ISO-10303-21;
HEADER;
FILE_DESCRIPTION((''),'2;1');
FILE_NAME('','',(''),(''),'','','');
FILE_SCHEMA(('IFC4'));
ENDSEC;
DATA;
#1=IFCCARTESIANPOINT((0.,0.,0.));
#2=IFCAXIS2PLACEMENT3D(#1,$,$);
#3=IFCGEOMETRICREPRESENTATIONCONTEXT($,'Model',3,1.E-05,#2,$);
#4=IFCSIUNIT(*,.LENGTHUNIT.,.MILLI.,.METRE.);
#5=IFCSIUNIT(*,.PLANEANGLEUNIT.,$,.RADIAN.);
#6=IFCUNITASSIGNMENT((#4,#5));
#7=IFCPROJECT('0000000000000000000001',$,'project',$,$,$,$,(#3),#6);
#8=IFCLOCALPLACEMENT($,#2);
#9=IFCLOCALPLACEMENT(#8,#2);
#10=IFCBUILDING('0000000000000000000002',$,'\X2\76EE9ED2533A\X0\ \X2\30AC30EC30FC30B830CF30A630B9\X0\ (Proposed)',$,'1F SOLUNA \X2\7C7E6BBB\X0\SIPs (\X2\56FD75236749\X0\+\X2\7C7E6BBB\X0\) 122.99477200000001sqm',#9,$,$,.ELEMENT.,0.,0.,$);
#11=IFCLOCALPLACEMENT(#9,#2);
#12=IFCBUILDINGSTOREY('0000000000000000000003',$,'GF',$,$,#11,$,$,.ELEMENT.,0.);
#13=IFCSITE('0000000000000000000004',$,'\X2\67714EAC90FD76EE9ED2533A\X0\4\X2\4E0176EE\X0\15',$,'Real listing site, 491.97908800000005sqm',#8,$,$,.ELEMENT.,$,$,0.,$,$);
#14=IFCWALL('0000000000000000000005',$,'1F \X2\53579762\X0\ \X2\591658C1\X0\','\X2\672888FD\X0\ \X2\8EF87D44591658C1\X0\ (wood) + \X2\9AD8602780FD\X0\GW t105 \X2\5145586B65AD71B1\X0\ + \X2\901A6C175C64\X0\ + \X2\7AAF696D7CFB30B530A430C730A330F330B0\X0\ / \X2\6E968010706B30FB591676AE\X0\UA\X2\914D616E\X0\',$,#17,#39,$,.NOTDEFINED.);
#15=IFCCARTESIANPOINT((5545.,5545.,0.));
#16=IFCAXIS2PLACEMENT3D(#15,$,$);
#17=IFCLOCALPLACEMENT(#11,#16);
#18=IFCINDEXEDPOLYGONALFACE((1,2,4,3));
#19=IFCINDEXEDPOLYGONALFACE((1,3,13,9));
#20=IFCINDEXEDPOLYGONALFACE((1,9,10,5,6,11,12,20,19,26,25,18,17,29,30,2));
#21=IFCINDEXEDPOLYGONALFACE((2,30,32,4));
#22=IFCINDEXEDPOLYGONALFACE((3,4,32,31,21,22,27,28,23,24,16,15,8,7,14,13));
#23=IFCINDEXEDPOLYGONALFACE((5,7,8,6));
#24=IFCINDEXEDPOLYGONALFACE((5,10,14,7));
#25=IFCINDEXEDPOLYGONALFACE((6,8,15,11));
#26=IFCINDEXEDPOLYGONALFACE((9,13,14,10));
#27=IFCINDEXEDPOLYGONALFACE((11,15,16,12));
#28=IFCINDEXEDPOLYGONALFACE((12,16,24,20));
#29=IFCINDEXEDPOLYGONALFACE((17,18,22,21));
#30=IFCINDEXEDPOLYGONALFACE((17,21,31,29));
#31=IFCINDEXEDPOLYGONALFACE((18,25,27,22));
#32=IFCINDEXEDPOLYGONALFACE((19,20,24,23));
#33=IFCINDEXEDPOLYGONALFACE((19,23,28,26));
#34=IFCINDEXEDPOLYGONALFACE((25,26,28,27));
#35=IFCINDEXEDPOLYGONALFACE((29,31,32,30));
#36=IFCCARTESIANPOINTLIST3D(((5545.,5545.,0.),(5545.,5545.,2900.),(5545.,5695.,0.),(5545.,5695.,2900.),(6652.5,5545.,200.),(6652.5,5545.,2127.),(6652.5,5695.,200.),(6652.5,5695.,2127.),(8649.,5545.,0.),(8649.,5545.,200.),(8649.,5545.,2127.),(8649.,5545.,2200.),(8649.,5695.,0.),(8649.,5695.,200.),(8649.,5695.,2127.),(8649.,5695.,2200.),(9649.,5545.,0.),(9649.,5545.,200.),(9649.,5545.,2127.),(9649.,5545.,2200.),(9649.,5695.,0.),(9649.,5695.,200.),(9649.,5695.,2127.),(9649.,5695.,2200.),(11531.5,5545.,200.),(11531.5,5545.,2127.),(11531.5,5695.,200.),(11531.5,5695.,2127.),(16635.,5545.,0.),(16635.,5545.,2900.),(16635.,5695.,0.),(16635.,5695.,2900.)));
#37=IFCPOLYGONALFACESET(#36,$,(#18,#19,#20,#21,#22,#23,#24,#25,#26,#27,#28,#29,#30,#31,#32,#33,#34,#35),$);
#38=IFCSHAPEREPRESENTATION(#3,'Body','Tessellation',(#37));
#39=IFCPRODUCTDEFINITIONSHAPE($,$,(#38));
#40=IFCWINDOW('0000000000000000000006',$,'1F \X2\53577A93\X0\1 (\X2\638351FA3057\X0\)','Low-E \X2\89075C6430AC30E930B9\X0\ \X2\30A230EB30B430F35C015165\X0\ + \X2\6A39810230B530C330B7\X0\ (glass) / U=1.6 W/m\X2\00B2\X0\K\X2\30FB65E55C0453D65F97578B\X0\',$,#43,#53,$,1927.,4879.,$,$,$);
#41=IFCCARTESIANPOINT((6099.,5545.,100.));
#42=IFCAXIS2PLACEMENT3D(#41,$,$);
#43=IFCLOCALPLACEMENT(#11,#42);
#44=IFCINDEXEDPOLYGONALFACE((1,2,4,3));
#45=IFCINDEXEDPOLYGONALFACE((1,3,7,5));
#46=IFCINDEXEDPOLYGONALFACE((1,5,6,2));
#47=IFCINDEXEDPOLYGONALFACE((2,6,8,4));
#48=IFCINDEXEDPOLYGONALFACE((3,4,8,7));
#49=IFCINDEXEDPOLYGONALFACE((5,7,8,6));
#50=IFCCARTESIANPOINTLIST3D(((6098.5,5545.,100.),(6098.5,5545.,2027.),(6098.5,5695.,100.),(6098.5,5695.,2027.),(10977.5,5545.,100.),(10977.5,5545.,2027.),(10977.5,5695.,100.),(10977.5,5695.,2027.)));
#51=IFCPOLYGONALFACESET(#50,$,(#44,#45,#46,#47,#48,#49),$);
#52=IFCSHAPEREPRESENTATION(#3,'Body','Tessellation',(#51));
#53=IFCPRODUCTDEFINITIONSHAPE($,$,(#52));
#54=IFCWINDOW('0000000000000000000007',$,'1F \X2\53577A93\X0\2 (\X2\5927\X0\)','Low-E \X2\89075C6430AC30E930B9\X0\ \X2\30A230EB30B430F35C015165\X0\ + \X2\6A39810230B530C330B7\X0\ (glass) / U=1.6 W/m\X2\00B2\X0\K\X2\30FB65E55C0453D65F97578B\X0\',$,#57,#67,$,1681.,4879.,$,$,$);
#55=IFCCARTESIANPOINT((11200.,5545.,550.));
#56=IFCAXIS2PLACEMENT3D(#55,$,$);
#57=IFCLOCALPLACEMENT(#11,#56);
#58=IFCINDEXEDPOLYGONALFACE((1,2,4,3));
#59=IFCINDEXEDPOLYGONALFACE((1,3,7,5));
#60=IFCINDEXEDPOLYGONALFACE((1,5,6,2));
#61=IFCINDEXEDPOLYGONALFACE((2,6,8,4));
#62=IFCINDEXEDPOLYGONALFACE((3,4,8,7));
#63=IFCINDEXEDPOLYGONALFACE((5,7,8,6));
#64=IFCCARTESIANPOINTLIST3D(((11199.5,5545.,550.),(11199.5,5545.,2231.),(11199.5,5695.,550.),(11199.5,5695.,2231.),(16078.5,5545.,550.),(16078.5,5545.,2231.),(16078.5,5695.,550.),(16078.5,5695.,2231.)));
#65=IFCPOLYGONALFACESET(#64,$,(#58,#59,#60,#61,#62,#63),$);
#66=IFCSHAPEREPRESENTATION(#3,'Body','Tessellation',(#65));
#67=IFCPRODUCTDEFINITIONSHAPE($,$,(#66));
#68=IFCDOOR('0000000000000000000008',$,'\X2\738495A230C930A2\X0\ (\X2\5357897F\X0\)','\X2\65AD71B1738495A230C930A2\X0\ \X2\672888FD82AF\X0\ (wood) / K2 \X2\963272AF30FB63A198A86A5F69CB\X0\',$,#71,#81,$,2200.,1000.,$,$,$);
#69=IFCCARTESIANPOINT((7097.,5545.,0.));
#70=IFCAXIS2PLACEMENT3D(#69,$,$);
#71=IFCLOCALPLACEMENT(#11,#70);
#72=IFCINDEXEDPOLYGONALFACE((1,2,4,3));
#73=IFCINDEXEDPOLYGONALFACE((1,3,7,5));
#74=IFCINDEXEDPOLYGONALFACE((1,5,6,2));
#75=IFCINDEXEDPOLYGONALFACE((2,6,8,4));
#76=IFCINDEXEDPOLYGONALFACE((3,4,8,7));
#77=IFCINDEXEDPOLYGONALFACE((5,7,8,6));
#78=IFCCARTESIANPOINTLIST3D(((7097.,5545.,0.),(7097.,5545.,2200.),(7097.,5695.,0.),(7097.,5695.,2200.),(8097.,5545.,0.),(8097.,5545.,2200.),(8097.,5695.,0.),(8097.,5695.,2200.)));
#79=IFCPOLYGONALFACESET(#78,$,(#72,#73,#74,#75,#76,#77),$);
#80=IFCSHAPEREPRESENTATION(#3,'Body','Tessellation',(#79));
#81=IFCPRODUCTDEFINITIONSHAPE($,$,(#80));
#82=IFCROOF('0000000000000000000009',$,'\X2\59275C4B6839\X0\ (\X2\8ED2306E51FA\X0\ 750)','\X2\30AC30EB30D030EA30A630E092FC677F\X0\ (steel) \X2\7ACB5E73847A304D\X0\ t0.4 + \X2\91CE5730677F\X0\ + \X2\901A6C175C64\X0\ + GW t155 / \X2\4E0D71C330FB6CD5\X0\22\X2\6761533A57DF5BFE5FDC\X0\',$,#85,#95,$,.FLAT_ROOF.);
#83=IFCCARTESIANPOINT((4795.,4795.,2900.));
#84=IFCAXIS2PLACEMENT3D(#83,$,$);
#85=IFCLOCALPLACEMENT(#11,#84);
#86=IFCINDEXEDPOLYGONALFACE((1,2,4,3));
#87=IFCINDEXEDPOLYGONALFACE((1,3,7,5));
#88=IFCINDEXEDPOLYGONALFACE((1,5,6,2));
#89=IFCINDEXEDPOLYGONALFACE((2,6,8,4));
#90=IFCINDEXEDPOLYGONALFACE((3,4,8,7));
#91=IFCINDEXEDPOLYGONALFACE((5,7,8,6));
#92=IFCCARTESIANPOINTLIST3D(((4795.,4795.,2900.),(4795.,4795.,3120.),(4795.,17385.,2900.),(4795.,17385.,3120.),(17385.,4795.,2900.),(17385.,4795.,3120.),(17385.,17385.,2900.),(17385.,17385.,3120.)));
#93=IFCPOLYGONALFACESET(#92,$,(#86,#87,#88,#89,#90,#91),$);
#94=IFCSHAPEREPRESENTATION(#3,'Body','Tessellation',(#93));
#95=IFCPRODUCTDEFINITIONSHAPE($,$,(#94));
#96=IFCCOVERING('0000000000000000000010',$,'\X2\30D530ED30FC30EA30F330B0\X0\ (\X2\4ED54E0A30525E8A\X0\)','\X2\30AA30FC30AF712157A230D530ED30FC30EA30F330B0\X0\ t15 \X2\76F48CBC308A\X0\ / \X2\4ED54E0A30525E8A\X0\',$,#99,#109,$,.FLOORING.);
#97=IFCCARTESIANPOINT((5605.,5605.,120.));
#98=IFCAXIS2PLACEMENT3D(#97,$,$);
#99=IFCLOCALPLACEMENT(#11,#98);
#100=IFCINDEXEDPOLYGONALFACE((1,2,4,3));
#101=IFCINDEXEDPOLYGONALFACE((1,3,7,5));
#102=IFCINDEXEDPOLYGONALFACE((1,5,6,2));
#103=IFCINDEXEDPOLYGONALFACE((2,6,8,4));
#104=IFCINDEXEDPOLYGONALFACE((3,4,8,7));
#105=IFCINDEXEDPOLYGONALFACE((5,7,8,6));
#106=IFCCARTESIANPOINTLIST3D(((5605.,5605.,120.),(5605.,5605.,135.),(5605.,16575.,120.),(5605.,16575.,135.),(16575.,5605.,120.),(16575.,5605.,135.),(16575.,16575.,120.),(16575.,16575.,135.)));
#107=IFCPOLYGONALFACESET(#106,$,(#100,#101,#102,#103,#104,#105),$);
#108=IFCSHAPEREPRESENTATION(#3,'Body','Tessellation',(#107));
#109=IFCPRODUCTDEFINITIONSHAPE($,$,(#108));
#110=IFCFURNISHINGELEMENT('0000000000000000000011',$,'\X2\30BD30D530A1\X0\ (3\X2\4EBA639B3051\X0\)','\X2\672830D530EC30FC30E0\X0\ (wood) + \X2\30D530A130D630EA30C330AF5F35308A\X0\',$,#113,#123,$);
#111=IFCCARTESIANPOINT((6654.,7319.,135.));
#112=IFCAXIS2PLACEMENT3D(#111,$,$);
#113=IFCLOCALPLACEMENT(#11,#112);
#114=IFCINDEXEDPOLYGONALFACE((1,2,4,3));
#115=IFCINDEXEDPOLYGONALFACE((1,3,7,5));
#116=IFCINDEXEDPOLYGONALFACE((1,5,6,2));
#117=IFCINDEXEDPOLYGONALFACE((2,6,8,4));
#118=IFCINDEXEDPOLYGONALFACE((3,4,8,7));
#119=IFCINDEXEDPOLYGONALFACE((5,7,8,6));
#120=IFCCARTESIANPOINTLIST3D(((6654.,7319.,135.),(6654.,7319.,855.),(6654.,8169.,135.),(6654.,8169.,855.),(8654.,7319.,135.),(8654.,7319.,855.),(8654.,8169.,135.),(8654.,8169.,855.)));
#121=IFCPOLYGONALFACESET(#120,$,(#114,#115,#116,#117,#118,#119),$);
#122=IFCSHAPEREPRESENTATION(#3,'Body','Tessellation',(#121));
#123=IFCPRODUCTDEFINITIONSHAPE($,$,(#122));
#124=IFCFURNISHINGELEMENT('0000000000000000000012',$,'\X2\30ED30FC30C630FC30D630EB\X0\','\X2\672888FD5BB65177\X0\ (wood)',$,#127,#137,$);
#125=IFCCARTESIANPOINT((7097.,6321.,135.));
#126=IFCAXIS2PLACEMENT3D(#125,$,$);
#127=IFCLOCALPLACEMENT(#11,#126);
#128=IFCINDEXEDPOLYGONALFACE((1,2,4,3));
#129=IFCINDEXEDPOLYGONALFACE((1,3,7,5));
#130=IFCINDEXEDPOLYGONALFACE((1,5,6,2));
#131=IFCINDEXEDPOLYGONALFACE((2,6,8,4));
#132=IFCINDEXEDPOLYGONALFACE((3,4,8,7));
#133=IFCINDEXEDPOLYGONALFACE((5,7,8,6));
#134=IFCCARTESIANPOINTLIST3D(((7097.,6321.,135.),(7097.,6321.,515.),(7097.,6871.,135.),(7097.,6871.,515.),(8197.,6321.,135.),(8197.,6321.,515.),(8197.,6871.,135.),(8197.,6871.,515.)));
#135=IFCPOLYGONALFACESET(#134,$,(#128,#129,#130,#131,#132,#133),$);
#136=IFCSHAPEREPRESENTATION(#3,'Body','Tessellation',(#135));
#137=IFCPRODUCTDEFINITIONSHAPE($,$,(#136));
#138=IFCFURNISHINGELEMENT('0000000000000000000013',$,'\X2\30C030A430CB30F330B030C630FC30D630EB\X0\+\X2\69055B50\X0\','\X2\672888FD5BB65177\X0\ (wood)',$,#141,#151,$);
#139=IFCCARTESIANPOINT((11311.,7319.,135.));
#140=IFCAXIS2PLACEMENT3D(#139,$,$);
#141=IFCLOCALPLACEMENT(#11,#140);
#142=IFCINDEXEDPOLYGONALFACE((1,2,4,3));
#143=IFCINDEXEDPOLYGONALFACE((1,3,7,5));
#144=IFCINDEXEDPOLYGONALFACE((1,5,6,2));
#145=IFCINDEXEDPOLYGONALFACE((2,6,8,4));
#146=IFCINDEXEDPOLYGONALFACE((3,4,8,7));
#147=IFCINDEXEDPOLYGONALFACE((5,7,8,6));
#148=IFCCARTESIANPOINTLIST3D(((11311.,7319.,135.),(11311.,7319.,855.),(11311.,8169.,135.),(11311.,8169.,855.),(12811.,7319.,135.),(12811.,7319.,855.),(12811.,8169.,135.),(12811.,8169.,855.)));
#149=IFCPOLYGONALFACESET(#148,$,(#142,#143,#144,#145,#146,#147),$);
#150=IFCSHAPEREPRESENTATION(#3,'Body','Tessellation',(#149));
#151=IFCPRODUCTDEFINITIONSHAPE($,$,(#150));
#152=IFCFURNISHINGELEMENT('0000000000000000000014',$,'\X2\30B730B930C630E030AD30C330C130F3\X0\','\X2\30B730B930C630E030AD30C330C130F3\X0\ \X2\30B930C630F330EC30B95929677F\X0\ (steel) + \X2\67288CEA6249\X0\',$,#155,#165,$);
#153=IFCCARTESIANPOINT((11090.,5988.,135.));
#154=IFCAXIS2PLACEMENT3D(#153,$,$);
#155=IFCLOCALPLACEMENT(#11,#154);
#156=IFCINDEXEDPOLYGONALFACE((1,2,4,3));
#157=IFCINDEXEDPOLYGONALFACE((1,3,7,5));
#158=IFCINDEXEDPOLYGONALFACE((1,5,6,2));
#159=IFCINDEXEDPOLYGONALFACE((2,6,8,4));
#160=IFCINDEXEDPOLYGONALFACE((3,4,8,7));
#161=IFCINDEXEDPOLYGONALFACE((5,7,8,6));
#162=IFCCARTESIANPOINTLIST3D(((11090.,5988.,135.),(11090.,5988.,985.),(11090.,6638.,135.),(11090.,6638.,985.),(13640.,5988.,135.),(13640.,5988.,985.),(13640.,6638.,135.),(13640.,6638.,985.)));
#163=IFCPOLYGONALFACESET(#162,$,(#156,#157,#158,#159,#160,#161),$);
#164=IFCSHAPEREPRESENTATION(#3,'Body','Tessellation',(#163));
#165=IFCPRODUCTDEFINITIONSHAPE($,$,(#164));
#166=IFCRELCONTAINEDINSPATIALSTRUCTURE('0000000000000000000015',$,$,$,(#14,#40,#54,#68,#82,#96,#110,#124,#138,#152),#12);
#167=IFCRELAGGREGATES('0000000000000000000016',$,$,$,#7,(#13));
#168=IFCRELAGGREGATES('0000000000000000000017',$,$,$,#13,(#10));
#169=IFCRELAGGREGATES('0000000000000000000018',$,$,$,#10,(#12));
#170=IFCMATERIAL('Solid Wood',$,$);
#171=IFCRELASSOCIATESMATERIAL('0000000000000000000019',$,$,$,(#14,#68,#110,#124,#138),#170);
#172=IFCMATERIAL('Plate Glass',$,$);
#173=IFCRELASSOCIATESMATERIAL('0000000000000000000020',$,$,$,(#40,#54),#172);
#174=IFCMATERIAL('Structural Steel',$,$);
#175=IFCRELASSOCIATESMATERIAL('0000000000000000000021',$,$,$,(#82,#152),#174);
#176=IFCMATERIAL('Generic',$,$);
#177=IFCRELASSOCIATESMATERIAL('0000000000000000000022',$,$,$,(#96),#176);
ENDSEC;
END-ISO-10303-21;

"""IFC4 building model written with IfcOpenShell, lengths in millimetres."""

from ifc_helpers import new_model, si_unit, frame, frame_2d, origin, place, context, project, spatial, rectangle, extrude, material, element, fill, save


model = new_model("IFC4")

# Units and contexts
model_context = context("Model", 3, precision=1e-05, world=origin())
ifc_project = project(units=[si_unit("LENGTHUNIT", "METRE", prefix="MILLI"), si_unit("PLANEANGLEUNIT", "RADIAN")], contexts=[model_context])

# Site, building, storey
site_placement = place(None, origin())
site = spatial("IfcSite", under=ifc_project, at=site_placement, Name="東京都目黒区4丁目15", ObjectType="Real listing site, 491.97908800000005sqm", CompositionType="ELEMENT", RefElevation=0.0)
building_placement = place(site_placement, origin())
building = spatial("IfcBuilding", under=site, at=building_placement, Name="目黒区 ガレージハウス (Proposed)", ObjectType="1F SOLUNA 籾殻SIPs (国産杉+籾殻) 122.99477200000001sqm", CompositionType="ELEMENT", ElevationOfRefHeight=0.0, ElevationOfTerrain=0.0)
storey_placement = place(building_placement, origin())
storey = spatial("IfcBuildingStorey", under=building, at=storey_placement, Name="GF", CompositionType="ELEMENT", Elevation=0.0)

# Shared definitions
ifc_material_1 = material(Name="Solid Wood")

# Wall, openings, windows, door
wall_1_placement = place(storey_placement, frame((5545.0, 5545.0, 0.0)))
wall_1 = element("IfcWall", 1, at=wall_1_placement, inside=storey, material=ifc_material_1, Name="1F 南面 外壁", Description="木製 軸組外壁 (wood) + 高性能GW t105 充填断熱 + 通気層 + 窯業系サイディング / 準耐火・外皮UA配慮", PredefinedType="NOTDEFINED", context=model_context, shape_type="SweptSolid", body=[
    extrude(rectangle(XDim=11090.0, YDim=150.0, at=frame_2d((5545.0, 75.0))), frame((5545.0, 5545.0, 0.0)), (0.0, 0.0, 1.0), 2900.0),
])
opening_1_placement = place(storey_placement, frame((6099.0, 5545.0, 100.0)))
opening_1 = element("IfcOpeningElement", 2, at=opening_1_placement, cuts=wall_1, PredefinedType="NOTDEFINED", context=model_context, shape_type="SweptSolid", body=[
    extrude(rectangle(XDim=4879.0, YDim=150.0, at=frame_2d((2439.0, 75.0))), frame((6099.0, 5545.0, 100.0)), (0.0, 0.0, 1.0), 1927.0),
])
opening_2_placement = place(storey_placement, frame((11200.0, 5545.0, 550.0)))
opening_2 = element("IfcOpeningElement", 3, at=opening_2_placement, cuts=wall_1, PredefinedType="NOTDEFINED", context=model_context, shape_type="SweptSolid", body=[
    extrude(rectangle(XDim=4879.0, YDim=150.0, at=frame_2d((2439.0, 75.0))), frame((11200.0, 5545.0, 550.0)), (0.0, 0.0, 1.0), 1681.0),
])
opening_3_placement = place(storey_placement, frame((7097.0, 5545.0, 0.0)))
opening_3 = element("IfcOpeningElement", 4, at=opening_3_placement, cuts=wall_1, PredefinedType="NOTDEFINED", context=model_context, shape_type="SweptSolid", body=[
    extrude(rectangle(XDim=1000.0, YDim=150.0, at=frame_2d((500.0, 75.0))), frame((7097.0, 5545.0, 0.0)), (0.0, 0.0, 1.0), 2200.0),
])
ifc_material_2 = material(Name="Plate Glass")
window_1_placement = place(storey_placement, frame((6099.0, 5545.0, 100.0)))
window_1 = element("IfcWindow", 5, at=window_1_placement, inside=storey, material=ifc_material_2, Name="1F 南窓1 (掃出し)", Description="Low-E 複層ガラス アルゴン封入 + 樹脂サッシ (glass) / U=1.6 W/m²K・日射取得型", OverallHeight=1927.0, OverallWidth=4879.0, context=model_context, shape_type="SweptSolid", body=[
    extrude(rectangle(XDim=4879.0, YDim=150.0, at=frame_2d((2439.0, 75.0))), frame((6099.0, 5545.0, 100.0)), (0.0, 0.0, 1.0), 1927.0),
])
fill(opening_1, window_1)
window_2_placement = place(storey_placement, frame((11200.0, 5545.0, 550.0)))
window_2 = element("IfcWindow", 6, at=window_2_placement, inside=storey, material=ifc_material_2, Name="1F 南窓2 (大)", Description="Low-E 複層ガラス アルゴン封入 + 樹脂サッシ (glass) / U=1.6 W/m²K・日射取得型", OverallHeight=1681.0, OverallWidth=4879.0, context=model_context, shape_type="SweptSolid", body=[
    extrude(rectangle(XDim=4879.0, YDim=150.0, at=frame_2d((2439.0, 75.0))), frame((11200.0, 5545.0, 550.0)), (0.0, 0.0, 1.0), 1681.0),
])
fill(opening_2, window_2)
door_placement = place(storey_placement, frame((7097.0, 5545.0, 0.0)))
door = element("IfcDoor", 7, at=door_placement, inside=storey, material=ifc_material_1, Name="玄関ドア (南西)", Description="断熱玄関ドア 木製芯 (wood) / K2 防犯・採風機構", OverallHeight=2200.0, OverallWidth=1000.0, context=model_context, shape_type="SweptSolid", body=[
    extrude(rectangle(XDim=1000.0, YDim=150.0, at=frame_2d((500.0, 75.0))), frame((7097.0, 5545.0, 0.0)), (0.0, 0.0, 1.0), 2200.0),
])
fill(opening_3, door)

# Roof
ifc_material_3 = material(Name="Structural Steel")
roof_placement = place(storey_placement, frame((4795.0, 4795.0, 2900.0)))
element("IfcRoof", 8, at=roof_placement, inside=storey, material=ifc_material_3, Name="大屋根 (軒の出 750)", Description="ガルバリウム鋼板 (steel) 立平葺き t0.4 + 野地板 + 通気層 + GW t155 / 不燃・法22条区域対応", PredefinedType="FLAT_ROOF", context=model_context, shape_type="SweptSolid", body=[
    extrude(rectangle(XDim=12590.0, YDim=12590.0, at=frame_2d((6295.0, 6295.0))), frame((4795.0, 4795.0, 2900.0)), (0.0, 0.0, 1.0), 220.0),
])

# Covering
ifc_material_4 = material(Name="Generic")
covering_placement = place(storey_placement, frame((5605.0, 5605.0, 120.0)))
element("IfcCovering", 9, at=covering_placement, inside=storey, material=ifc_material_4, Name="フローリング (仕上げ床)", Description="オーク無垢フローリング t15 直貼り / 仕上げ床", PredefinedType="FLOORING", context=model_context, shape_type="SweptSolid", body=[
    extrude(rectangle(XDim=10970.0, YDim=10970.0, at=frame_2d((5485.0, 5485.0))), frame((5605.0, 5605.0, 120.0)), (0.0, 0.0, 1.0), 15.0),
])

# Furnishing elements
furnishing_1_placement = place(storey_placement, frame((6654.0, 7319.0, 135.0)))
element("IfcFurnishingElement", 10, at=furnishing_1_placement, inside=storey, material=ifc_material_1, Name="ソファ (3人掛け)", Description="木フレーム (wood) + ファブリック張り", context=model_context, shape_type="SweptSolid", body=[
    extrude(rectangle(XDim=2000.0, YDim=850.0, at=frame_2d((1000.0, 425.0))), frame((6654.0, 7319.0, 135.0)), (0.0, 0.0, 1.0), 720.0),
])
furnishing_2_placement = place(storey_placement, frame((7097.0, 6321.0, 135.0)))
element("IfcFurnishingElement", 11, at=furnishing_2_placement, inside=storey, material=ifc_material_1, Name="ローテーブル", Description="木製家具 (wood)", context=model_context, shape_type="SweptSolid", body=[
    extrude(rectangle(XDim=1100.0, YDim=550.0, at=frame_2d((550.0, 275.0))), frame((7097.0, 6321.0, 135.0)), (0.0, 0.0, 1.0), 380.0),
])
furnishing_3_placement = place(storey_placement, frame((11311.0, 7319.0, 135.0)))
element("IfcFurnishingElement", 12, at=furnishing_3_placement, inside=storey, material=ifc_material_1, Name="ダイニングテーブル+椅子", Description="木製家具 (wood)", context=model_context, shape_type="SweptSolid", body=[
    extrude(rectangle(XDim=1500.0, YDim=850.0, at=frame_2d((750.0, 425.0))), frame((11311.0, 7319.0, 135.0)), (0.0, 0.0, 1.0), 720.0),
])
furnishing_4_placement = place(storey_placement, frame((11090.0, 5988.0, 135.0)))
element("IfcFurnishingElement", 13, at=furnishing_4_placement, inside=storey, material=ifc_material_3, Name="システムキッチン", Description="システムキッチン ステンレス天板 (steel) + 木質扉", context=model_context, shape_type="SweptSolid", body=[
    extrude(rectangle(XDim=2550.0, YDim=650.0, at=frame_2d((1275.0, 325.0))), frame((11090.0, 5988.0, 135.0)), (0.0, 0.0, 1.0), 850.0),
])

save(model, "model.ifc")
